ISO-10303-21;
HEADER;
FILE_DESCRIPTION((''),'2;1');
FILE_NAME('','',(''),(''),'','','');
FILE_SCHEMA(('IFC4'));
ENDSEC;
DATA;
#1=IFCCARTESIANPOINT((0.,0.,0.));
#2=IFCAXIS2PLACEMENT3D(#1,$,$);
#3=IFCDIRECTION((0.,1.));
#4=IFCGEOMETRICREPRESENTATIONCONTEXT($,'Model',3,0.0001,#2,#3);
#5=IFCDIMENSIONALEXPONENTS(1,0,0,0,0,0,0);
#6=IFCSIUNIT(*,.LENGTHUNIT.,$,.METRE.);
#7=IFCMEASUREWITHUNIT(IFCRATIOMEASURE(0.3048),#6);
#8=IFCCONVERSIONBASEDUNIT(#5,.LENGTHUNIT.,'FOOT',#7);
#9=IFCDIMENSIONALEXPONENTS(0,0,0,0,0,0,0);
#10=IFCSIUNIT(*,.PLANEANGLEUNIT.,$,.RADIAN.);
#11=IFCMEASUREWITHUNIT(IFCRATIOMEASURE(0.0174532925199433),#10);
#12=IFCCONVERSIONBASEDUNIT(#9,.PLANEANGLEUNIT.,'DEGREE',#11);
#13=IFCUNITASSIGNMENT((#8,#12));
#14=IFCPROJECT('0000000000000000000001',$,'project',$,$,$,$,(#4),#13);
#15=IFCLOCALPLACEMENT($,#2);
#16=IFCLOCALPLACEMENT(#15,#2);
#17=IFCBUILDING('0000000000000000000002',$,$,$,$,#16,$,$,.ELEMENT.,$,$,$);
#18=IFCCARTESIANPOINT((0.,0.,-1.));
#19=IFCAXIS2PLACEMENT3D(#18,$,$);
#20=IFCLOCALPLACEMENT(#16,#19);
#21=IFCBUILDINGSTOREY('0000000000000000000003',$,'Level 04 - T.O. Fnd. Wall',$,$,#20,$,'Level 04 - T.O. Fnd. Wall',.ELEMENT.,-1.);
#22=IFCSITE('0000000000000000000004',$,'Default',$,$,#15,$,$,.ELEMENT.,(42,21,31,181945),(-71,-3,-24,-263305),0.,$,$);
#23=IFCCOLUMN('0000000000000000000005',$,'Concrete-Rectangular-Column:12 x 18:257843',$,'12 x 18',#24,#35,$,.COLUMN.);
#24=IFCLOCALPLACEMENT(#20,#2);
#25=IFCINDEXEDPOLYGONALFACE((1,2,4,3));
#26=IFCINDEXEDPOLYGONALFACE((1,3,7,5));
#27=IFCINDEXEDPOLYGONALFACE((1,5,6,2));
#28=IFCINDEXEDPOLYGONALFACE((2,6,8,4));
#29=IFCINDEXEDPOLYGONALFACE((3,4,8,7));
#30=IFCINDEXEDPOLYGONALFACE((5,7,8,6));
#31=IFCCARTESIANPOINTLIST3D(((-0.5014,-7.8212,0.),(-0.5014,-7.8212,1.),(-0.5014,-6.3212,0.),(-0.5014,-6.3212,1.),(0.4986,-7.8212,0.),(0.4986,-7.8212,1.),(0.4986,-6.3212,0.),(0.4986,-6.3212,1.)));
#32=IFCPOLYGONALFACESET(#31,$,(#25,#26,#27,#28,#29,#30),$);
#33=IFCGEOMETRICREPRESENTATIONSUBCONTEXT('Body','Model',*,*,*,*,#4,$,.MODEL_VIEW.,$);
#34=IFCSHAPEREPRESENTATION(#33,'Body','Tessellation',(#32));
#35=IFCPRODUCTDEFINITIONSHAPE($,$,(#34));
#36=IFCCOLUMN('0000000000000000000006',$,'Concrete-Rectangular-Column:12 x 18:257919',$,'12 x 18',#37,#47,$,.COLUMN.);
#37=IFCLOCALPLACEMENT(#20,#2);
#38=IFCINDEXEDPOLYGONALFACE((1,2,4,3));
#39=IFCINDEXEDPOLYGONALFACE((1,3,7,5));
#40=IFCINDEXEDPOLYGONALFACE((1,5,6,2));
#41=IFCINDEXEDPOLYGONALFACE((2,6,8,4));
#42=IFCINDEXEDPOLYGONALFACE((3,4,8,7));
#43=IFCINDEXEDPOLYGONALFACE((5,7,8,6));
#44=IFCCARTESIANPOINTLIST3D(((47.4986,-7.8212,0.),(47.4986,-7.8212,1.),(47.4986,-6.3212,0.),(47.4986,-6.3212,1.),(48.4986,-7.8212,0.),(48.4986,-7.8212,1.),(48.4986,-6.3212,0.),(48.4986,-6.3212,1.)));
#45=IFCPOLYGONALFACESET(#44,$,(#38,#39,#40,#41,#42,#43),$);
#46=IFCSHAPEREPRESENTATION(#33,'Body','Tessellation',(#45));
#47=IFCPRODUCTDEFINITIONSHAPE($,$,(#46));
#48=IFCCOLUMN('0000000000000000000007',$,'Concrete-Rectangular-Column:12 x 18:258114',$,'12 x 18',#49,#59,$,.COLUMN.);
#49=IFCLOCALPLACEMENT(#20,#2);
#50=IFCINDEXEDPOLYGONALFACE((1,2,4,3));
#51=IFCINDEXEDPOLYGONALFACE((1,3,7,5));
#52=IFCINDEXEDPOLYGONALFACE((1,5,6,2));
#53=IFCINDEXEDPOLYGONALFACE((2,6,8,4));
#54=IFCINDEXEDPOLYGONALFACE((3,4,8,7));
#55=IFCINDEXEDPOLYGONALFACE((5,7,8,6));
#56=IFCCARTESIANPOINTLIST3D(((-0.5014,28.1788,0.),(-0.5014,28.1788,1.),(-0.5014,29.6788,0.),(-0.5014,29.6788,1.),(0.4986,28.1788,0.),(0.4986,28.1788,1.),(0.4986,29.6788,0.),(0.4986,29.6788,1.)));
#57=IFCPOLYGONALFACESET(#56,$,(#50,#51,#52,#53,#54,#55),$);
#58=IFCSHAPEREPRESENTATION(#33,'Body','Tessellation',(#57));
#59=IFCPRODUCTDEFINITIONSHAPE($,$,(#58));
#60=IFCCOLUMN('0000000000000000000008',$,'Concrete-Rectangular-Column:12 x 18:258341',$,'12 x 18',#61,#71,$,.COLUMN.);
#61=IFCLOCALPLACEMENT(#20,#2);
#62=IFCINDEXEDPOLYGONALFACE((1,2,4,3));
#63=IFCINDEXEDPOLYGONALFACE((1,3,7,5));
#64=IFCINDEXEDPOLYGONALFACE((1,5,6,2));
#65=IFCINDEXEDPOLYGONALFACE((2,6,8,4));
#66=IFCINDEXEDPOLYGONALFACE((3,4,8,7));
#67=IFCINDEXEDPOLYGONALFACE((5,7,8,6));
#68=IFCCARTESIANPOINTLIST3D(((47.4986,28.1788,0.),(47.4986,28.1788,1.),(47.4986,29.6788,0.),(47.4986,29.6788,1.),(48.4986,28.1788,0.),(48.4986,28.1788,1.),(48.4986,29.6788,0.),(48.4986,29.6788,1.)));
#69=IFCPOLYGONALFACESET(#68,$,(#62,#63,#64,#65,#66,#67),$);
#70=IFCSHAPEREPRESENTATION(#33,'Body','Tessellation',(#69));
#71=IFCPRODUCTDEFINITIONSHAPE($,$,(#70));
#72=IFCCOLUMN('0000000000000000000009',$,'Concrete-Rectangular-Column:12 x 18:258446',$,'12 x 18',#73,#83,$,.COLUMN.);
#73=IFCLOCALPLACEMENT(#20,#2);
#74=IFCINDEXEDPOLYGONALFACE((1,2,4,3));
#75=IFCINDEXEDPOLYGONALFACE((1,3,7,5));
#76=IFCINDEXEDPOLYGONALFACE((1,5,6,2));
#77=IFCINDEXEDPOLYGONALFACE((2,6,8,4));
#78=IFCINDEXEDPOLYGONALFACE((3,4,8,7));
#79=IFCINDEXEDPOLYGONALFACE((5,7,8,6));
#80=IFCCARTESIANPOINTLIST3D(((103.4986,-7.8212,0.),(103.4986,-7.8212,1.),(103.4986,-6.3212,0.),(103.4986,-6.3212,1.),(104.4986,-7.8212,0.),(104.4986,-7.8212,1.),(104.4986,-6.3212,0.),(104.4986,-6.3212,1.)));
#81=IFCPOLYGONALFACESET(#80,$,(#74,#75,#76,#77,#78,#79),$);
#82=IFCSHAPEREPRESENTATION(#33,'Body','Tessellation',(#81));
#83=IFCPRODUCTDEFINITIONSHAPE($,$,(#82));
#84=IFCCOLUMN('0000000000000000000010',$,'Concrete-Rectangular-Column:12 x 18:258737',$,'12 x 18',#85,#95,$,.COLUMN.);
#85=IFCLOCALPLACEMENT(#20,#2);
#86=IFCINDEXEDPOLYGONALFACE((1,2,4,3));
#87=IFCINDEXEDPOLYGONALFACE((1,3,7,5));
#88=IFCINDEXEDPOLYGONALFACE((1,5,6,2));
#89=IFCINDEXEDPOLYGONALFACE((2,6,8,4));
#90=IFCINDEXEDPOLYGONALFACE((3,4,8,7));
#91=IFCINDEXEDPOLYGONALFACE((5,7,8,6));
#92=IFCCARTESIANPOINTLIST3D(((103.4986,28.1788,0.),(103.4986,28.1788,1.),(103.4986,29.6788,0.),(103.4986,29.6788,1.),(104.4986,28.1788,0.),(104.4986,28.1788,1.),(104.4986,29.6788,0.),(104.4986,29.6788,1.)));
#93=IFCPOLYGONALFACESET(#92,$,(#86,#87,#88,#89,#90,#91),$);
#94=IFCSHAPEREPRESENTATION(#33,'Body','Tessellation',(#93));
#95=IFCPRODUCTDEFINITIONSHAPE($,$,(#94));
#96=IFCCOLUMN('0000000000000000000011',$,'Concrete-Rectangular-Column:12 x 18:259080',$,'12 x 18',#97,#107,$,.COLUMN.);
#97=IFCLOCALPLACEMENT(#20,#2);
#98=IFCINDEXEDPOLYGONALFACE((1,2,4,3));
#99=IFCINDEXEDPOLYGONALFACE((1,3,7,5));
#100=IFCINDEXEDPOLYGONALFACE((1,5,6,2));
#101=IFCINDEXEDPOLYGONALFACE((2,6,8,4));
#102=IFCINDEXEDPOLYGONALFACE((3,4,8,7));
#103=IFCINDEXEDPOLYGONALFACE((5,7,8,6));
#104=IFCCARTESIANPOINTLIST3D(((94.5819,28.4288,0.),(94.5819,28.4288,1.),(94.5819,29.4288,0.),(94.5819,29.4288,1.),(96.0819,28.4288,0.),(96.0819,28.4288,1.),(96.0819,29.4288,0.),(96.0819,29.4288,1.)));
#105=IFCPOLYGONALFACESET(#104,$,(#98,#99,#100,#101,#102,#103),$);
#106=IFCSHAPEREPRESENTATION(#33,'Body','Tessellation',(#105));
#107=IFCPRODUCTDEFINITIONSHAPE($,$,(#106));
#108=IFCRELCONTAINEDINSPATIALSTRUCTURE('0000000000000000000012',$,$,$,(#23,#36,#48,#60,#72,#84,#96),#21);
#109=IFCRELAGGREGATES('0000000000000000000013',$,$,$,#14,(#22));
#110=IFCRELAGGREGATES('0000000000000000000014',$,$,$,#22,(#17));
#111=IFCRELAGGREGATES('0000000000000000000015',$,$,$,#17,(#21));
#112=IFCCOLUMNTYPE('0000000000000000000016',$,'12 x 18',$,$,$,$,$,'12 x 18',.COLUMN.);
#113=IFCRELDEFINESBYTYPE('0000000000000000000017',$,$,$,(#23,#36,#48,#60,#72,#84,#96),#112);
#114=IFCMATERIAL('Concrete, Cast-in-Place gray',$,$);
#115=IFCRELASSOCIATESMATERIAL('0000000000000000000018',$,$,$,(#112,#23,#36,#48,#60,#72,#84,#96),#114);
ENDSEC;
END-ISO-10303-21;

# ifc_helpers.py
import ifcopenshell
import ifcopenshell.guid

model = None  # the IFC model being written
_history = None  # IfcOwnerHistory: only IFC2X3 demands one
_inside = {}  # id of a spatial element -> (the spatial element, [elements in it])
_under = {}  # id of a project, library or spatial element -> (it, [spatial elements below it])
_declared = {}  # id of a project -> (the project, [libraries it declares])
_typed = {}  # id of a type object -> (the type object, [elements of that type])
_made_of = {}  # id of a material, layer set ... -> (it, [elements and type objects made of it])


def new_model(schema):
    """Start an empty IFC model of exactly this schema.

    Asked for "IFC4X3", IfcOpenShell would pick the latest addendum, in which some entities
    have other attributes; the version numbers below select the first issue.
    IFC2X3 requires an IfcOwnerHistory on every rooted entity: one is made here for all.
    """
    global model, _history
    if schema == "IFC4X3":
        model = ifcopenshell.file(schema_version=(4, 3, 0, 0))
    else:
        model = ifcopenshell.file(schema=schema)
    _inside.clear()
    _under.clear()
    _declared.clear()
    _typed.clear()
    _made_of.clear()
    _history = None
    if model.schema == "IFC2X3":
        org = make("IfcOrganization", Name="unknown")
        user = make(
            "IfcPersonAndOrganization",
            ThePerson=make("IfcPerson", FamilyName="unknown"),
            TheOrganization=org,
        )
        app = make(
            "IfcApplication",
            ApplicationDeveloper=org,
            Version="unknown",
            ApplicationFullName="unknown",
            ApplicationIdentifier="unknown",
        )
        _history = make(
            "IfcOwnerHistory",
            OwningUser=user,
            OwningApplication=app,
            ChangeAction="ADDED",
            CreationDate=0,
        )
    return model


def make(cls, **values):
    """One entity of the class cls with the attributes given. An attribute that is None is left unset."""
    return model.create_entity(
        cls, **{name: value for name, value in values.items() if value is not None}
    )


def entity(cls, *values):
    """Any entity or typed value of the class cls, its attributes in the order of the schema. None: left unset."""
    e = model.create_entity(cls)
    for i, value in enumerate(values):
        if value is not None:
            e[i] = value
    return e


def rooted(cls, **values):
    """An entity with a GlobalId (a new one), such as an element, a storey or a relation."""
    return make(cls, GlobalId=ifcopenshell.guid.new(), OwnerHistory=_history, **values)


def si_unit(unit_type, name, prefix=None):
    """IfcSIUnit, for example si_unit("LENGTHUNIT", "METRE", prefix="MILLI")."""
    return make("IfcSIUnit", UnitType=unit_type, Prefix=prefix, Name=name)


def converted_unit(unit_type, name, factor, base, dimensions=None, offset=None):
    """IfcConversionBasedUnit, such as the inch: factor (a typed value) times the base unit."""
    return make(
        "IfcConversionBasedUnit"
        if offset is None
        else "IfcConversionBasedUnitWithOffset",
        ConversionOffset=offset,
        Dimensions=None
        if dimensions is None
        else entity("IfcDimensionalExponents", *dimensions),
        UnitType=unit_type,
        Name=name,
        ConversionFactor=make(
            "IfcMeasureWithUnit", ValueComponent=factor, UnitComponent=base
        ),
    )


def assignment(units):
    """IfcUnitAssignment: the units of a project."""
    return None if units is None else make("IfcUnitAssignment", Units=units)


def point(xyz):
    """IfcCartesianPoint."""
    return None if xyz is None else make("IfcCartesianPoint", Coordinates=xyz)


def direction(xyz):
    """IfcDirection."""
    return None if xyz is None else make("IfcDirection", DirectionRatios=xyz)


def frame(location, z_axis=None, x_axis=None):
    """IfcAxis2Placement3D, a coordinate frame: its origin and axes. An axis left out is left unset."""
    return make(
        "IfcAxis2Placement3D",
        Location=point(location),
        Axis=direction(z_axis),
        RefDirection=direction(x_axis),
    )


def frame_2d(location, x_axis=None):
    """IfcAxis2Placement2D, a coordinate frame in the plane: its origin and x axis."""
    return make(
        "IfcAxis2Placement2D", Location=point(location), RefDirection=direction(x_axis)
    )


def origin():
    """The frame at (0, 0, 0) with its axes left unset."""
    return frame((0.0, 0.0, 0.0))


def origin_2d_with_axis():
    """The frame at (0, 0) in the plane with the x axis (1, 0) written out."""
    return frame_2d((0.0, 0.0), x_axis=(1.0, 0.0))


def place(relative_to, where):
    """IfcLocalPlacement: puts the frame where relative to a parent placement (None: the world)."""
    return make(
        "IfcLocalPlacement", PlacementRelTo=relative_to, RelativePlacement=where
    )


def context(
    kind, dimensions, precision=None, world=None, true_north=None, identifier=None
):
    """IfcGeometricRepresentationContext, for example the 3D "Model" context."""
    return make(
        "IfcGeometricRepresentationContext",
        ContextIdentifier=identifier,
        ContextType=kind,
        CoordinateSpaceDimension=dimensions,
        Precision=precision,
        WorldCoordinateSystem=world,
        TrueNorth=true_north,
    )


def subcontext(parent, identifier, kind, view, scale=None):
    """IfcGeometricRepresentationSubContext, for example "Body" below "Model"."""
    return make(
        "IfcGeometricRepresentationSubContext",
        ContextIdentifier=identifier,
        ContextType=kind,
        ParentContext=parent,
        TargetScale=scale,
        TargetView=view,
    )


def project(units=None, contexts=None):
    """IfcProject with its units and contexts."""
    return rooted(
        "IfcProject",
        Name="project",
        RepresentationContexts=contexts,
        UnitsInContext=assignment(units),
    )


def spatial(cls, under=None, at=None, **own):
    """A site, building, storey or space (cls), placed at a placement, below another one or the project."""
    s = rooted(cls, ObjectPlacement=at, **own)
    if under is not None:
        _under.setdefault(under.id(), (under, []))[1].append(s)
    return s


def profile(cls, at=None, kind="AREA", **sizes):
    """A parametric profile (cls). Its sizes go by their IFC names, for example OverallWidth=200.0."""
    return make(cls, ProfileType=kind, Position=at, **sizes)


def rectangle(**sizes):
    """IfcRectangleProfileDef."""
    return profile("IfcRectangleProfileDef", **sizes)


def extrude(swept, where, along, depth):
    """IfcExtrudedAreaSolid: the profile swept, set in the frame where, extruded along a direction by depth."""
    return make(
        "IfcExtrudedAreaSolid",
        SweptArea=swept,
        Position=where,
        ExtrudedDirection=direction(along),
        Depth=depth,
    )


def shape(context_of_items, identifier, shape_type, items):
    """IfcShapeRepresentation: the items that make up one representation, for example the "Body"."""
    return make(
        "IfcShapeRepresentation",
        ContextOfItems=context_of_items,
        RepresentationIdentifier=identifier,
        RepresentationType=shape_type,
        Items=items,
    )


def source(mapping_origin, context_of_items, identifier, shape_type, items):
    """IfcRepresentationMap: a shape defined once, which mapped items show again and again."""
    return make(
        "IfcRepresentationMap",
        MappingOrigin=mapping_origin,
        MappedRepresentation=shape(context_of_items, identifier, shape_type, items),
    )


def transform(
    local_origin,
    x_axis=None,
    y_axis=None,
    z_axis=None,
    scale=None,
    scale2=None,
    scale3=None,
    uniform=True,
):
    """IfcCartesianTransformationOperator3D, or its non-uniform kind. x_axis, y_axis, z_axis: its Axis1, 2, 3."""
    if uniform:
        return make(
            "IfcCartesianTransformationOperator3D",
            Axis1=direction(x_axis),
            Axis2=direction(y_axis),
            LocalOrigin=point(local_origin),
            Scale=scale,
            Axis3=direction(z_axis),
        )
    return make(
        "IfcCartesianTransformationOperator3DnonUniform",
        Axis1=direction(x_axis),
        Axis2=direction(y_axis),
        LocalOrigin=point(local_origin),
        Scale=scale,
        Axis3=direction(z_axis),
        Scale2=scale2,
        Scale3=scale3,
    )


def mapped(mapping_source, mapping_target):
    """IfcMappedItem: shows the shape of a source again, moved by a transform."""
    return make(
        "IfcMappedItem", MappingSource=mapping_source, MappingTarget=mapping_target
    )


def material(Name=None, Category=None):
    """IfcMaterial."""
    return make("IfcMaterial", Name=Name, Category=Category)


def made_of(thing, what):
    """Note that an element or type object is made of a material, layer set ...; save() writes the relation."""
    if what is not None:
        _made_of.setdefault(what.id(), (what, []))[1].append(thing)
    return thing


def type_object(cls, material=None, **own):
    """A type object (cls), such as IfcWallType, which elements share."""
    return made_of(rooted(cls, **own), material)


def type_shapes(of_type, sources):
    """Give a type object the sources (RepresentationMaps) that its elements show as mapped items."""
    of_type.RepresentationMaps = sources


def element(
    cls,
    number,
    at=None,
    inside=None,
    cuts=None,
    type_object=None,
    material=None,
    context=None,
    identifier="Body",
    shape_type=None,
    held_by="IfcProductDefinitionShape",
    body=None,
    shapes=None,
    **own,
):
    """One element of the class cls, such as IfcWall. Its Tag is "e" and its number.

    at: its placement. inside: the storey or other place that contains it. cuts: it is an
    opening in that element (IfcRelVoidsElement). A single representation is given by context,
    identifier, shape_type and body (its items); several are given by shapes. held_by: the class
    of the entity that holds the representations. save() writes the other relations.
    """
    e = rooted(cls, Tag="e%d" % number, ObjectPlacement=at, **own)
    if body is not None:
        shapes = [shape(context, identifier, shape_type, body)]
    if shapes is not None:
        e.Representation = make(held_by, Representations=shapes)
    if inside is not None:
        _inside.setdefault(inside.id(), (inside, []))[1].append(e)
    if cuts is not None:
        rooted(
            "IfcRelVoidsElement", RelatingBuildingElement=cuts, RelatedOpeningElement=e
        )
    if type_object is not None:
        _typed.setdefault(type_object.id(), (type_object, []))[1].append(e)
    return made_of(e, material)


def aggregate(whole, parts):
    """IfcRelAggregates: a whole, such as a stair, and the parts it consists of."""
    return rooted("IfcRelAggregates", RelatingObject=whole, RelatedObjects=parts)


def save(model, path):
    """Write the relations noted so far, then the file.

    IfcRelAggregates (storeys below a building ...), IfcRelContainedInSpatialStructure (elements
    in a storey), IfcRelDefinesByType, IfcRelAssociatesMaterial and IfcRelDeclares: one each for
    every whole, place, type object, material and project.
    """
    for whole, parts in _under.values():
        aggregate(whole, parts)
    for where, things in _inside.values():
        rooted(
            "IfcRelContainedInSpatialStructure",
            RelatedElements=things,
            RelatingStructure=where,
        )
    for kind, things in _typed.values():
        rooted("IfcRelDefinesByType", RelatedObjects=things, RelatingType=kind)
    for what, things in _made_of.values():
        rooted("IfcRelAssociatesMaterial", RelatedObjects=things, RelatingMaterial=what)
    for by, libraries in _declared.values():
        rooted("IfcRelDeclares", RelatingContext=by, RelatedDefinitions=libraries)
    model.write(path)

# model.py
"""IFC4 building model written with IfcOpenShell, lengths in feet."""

from ifc_helpers import new_model, entity, si_unit, converted_unit, direction, frame, origin, origin_2d_with_axis, place, context, subcontext, project, spatial, rectangle, extrude, source, transform, mapped, material, type_object, type_shapes, element, save


model = new_model("IFC4")

# Units and contexts
model_context = context("Model", 3, precision=0.0001, world=origin(), true_north=direction((0.0, 1.0)))
body_context = subcontext(model_context, "Body", "Model", "MODEL_VIEW")
ifc_project = project(units=[converted_unit("LENGTHUNIT", "FOOT", entity("IfcRatioMeasure", 0.3048), si_unit("LENGTHUNIT", "METRE"), dimensions=[1, 0, 0, 0, 0, 0, 0]), converted_unit("PLANEANGLEUNIT", "DEGREE", entity("IfcRatioMeasure", 0.0174532925199433), si_unit("PLANEANGLEUNIT", "RADIAN"), dimensions=[0, 0, 0, 0, 0, 0, 0])], contexts=[model_context])

# Site, building, storey
site_placement = place(None, origin())
site = spatial("IfcSite", under=ifc_project, at=site_placement, Name="Default", CompositionType="ELEMENT", RefLatitude=(42, 21, 31, 181945), RefLongitude=(-71, -3, -24, -263305), RefElevation=0.0)
building_placement = place(site_placement, origin())
building = spatial("IfcBuilding", under=site, at=building_placement, CompositionType="ELEMENT")
storey_placement = place(building_placement, frame((0.0, 0.0, -1.0)))
storey = spatial("IfcBuildingStorey", under=building, at=storey_placement, Name="Level 04 - T.O. Fnd. Wall", LongName="Level 04 - T.O. Fnd. Wall", CompositionType="ELEMENT", Elevation=-1.0)

# Columns
ifc_material = material(Name="Concrete, Cast-in-Place gray")
column_type = type_object("IfcColumnType", Name="12 x 18", ElementType="12 x 18", PredefinedType="COLUMN", material=ifc_material)
shared_shape = source(origin(), body_context, "Body", "SweptSolid", [
    extrude(rectangle(XDim=1.5, YDim=1.0, at=origin_2d_with_axis()), frame((0.0, 0.0, -1.0), z_axis=(0.0, 0.0, 1.0), x_axis=(0.0, -1.0, 0.0)), (0.0, 0.0, 1.0), 1.0),
])
type_shapes(column_type, [shared_shape])
for number, where, name in (
    (1, (-0.0014, -7.0712, 1.0), "Concrete-Rectangular-Column:12 x 18:257843"),
    (2, (47.9986, -7.0712, 1.0), "Concrete-Rectangular-Column:12 x 18:257919"),
    (3, (-0.0014, 28.9288, 1.0), "Concrete-Rectangular-Column:12 x 18:258114"),
    (4, (47.9986, 28.9288, 1.0), "Concrete-Rectangular-Column:12 x 18:258341"),
    (5, (103.9986, -7.0712, 1.0), "Concrete-Rectangular-Column:12 x 18:258446"),
    (6, (103.9986, 28.9288, 1.0), "Concrete-Rectangular-Column:12 x 18:258737"),
):
    element("IfcColumn", number, at=place(storey_placement, frame(where)), inside=storey, type_object=column_type, material=ifc_material, Name=name, ObjectType="12 x 18", PredefinedType="COLUMN", context=body_context, shape_type="MappedRepresentation", body=[
        mapped(shared_shape, transform((0.0, 0.0, 0.0), scale=1.0)),
    ])
column_placement = place(storey_placement, frame((95.3319, 28.9288, 1.0), z_axis=(0.0, 0.0, 1.0), x_axis=(0.0, 1.0, 0.0)))
element("IfcColumn", 7, at=column_placement, inside=storey, type_object=column_type, material=ifc_material, Name="Concrete-Rectangular-Column:12 x 18:259080", ObjectType="12 x 18", PredefinedType="COLUMN", context=body_context, shape_type="MappedRepresentation", body=[
    mapped(shared_shape, transform((0.0, 0.0, 0.0), scale=1.0)),
])

save(model, "model.ifc")
